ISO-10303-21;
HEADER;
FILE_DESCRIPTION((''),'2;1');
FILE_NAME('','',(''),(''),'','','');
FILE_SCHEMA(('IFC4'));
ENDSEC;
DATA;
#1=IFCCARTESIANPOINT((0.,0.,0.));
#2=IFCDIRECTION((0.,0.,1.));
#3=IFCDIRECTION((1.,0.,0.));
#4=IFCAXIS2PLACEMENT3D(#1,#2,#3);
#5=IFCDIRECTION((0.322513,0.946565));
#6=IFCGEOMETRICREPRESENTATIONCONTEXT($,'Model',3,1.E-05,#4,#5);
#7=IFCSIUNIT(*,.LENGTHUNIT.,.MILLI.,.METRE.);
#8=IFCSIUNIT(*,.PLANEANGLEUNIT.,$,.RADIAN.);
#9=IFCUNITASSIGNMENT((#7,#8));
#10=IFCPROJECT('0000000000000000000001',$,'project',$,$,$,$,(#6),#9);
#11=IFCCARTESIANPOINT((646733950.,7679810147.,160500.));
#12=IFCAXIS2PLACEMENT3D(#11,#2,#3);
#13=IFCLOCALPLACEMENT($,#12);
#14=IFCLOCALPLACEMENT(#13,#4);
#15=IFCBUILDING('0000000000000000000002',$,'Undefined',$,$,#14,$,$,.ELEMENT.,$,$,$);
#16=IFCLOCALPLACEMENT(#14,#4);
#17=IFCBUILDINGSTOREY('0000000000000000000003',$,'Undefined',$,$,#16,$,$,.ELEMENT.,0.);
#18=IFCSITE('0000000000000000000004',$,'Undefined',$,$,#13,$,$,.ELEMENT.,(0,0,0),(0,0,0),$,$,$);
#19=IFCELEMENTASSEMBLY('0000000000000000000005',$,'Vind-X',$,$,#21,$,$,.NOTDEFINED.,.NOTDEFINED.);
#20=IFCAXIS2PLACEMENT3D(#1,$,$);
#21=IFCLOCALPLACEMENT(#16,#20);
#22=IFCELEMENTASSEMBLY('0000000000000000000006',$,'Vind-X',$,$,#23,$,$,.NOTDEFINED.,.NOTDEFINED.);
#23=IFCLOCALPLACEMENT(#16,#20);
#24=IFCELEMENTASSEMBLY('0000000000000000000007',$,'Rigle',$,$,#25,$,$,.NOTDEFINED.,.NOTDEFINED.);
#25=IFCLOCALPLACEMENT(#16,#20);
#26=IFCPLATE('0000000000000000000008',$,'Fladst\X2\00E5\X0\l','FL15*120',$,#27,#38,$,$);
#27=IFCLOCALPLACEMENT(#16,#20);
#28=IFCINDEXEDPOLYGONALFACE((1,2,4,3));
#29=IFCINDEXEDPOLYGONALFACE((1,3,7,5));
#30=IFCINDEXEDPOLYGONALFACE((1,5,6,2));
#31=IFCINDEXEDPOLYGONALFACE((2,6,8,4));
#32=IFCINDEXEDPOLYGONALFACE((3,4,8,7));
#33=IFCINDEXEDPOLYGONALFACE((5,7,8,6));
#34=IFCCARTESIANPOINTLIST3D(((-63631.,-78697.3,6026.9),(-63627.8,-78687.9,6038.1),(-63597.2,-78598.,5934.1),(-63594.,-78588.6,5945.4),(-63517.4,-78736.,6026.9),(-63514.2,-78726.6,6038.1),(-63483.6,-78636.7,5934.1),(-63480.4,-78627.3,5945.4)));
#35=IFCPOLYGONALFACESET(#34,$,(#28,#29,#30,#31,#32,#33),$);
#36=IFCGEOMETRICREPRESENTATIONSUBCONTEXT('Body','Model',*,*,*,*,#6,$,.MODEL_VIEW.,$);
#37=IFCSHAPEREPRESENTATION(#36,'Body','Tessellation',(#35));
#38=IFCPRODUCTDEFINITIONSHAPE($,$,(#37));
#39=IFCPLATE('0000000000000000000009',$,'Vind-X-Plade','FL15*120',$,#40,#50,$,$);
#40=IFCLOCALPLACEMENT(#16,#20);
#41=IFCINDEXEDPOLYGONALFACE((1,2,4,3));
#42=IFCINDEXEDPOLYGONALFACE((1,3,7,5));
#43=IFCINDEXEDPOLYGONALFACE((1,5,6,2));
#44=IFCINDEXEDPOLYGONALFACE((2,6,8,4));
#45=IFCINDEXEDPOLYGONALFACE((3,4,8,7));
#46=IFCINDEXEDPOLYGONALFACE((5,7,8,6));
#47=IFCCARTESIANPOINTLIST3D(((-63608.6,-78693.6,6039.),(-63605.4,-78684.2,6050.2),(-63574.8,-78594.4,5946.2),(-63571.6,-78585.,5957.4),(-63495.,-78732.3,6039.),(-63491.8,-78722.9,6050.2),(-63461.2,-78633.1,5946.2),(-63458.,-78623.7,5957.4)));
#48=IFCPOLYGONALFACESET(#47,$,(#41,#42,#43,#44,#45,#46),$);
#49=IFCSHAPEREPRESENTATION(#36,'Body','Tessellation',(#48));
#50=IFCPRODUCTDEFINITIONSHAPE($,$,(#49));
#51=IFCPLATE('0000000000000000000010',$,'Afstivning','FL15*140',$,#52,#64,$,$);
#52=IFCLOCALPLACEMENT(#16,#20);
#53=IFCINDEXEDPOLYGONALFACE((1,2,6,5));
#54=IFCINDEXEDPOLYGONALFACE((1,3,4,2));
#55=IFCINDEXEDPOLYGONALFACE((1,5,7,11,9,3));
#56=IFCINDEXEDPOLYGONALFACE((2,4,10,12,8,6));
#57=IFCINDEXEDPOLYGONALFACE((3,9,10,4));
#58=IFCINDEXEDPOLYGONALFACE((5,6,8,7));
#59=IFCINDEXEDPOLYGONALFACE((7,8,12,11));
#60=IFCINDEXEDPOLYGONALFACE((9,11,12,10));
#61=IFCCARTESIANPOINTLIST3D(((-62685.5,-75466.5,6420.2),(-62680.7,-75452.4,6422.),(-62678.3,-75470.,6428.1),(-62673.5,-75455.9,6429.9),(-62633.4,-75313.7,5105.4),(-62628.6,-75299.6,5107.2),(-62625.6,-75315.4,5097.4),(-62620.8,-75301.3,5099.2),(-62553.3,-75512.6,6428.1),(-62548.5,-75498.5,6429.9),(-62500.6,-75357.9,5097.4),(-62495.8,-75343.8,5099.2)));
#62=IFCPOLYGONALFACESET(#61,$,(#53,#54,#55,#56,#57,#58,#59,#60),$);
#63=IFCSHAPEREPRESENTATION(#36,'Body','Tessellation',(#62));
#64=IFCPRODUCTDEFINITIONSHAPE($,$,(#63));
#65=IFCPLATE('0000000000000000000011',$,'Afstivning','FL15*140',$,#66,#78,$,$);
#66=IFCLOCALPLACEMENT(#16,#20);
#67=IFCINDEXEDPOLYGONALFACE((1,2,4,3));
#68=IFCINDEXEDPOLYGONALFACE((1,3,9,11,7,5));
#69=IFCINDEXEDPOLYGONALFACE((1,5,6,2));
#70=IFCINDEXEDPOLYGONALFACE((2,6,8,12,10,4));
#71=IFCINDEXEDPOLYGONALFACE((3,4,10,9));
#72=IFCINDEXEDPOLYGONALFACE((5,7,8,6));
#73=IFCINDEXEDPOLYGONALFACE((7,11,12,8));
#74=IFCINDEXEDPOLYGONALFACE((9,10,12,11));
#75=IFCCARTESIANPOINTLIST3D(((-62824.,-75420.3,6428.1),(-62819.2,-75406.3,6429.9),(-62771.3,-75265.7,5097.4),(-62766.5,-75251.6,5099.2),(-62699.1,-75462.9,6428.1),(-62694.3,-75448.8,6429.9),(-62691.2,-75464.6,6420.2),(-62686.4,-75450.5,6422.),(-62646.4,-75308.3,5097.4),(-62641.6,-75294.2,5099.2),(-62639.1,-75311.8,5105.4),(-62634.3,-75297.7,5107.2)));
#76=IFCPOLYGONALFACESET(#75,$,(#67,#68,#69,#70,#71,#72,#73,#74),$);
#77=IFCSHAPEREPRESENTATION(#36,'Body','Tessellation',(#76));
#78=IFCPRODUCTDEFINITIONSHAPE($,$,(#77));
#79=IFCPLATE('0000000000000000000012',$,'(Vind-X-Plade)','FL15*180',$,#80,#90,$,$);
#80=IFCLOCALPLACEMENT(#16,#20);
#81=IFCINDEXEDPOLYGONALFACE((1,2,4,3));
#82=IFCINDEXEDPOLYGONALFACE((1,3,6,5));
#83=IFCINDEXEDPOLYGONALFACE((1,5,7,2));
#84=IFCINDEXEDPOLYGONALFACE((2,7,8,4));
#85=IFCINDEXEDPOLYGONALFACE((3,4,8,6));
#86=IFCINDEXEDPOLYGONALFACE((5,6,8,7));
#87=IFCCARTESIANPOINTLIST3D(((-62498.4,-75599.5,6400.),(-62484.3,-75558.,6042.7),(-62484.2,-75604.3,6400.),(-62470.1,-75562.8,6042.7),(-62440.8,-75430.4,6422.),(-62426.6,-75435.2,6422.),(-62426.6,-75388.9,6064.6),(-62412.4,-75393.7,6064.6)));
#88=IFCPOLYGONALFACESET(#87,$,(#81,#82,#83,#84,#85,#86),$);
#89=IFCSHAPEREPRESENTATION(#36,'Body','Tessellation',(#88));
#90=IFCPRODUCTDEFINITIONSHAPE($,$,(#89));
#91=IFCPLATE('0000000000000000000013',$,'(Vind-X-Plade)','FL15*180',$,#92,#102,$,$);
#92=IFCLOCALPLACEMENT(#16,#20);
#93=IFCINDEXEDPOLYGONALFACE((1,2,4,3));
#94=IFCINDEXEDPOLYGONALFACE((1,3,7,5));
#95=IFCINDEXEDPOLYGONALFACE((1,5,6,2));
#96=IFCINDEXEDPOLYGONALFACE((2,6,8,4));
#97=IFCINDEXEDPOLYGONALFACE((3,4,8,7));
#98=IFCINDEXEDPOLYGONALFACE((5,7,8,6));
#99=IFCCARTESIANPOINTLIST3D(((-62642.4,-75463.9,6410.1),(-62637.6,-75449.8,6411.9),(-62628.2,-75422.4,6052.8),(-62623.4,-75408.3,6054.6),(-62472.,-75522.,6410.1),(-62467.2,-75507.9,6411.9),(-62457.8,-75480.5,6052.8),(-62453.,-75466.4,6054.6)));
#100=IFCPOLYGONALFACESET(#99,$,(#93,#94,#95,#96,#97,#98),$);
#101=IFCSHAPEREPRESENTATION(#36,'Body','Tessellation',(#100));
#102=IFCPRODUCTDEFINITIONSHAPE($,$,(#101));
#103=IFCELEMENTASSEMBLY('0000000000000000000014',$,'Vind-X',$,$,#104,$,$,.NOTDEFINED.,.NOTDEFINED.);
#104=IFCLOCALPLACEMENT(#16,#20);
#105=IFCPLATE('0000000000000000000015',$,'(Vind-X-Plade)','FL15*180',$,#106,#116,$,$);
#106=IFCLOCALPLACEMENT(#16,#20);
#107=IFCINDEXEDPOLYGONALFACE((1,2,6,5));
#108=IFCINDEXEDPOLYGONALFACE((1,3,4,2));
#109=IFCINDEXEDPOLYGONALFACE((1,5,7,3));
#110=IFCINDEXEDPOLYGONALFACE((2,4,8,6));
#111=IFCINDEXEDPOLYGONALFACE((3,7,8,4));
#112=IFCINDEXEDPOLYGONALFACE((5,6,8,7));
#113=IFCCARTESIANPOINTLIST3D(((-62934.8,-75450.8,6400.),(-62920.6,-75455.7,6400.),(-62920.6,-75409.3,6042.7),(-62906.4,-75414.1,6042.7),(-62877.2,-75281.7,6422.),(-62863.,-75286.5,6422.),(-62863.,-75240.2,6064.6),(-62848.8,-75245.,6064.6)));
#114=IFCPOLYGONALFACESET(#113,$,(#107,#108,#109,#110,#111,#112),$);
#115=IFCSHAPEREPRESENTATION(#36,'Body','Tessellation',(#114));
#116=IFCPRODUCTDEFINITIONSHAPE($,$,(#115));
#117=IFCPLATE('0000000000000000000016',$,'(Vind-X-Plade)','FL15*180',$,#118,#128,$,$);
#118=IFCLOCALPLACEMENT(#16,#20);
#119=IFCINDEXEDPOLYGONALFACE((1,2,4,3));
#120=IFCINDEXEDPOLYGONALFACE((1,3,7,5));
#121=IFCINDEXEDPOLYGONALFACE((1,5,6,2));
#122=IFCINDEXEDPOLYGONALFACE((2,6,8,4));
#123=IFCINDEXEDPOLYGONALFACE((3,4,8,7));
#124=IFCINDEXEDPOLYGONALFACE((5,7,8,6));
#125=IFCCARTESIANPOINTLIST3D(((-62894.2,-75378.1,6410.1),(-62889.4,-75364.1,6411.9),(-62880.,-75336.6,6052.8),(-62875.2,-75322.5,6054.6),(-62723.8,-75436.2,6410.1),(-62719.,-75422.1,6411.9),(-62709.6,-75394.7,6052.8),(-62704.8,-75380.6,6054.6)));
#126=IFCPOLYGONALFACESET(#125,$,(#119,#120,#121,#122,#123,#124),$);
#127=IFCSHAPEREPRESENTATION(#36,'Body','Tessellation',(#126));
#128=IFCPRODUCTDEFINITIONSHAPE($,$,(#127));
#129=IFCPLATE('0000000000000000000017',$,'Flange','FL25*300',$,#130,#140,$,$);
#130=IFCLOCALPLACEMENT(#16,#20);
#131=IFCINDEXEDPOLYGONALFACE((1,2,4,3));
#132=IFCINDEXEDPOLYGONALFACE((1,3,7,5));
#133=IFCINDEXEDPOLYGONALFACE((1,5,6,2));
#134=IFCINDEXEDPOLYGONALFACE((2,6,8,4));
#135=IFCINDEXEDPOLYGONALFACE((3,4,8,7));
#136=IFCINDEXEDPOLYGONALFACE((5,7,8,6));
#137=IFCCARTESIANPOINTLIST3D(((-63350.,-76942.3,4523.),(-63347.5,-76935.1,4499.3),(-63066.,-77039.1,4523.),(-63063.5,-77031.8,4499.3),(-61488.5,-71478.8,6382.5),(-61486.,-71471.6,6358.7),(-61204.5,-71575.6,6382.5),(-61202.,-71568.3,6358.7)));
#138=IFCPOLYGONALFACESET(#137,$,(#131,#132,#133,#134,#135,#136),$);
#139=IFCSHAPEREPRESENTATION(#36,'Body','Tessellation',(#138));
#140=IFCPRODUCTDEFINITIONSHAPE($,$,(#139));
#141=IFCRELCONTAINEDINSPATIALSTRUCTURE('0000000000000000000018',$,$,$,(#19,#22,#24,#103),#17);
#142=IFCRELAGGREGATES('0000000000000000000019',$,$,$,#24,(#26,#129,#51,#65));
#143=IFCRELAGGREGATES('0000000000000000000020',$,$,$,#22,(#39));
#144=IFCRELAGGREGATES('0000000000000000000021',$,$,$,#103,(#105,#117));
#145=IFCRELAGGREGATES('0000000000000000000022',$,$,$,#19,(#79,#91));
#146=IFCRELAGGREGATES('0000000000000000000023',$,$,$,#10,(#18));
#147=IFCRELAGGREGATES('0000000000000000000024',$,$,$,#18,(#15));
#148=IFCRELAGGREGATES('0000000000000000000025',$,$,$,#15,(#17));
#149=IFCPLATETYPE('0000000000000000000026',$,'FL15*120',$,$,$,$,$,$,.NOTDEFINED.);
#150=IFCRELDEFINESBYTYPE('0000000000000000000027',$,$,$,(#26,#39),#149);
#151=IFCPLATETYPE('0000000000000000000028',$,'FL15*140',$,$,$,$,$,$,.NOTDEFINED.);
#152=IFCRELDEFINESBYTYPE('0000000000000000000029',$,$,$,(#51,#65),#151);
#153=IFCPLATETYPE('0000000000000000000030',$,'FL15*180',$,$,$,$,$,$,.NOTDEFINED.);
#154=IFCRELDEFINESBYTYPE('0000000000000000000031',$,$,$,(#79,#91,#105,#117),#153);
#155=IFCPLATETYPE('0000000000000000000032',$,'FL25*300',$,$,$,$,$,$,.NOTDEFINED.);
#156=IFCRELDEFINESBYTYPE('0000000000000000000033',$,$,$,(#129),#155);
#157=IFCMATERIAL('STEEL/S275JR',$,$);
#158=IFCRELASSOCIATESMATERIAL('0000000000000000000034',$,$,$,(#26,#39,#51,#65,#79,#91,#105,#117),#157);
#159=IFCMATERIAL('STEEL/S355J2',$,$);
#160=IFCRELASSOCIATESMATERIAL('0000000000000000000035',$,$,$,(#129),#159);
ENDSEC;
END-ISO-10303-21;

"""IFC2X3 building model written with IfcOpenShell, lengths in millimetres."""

from ifc_helpers import new_model, si_unit, direction, frame, origin_with_axes, place, context, subcontext, project, spatial, polyline, outline, extrude, clip, halfspace, material, type_object, element, aggregate, save


model = new_model("IFC2X3")

# Units and contexts
model_context = context("Model", 3, precision=1e-05, world=origin_with_axes(), true_north=direction((0.322513, 0.946565)))
body_context = subcontext(model_context, "Body", "Model", "MODEL_VIEW")
ifc_project = project(units=[si_unit("LENGTHUNIT", "METRE", prefix="MILLI"), si_unit("PLANEANGLEUNIT", "RADIAN")], contexts=[model_context])

# Site, building, storey
site_placement = place(None, frame((646733950.0, 7679810147.0, 160500.0), z_axis=(0.0, 0.0, 1.0), x_axis=(1.0, 0.0, 0.0)))
site = spatial("IfcSite", under=ifc_project, at=site_placement, Name="Undefined", CompositionType="ELEMENT", RefLatitude=(0, 0, 0), RefLongitude=(0, 0, 0))
building_placement = place(site_placement, origin_with_axes())
building = spatial("IfcBuilding", under=site, at=building_placement, Name="Undefined", CompositionType="ELEMENT")
storey_placement = place(building_placement, origin_with_axes())
storey = spatial("IfcBuildingStorey", under=building, at=storey_placement, Name="Undefined", CompositionType="ELEMENT", Elevation=0.0)

# Shared definitions
ifc_material_1 = material(Name="STEEL/S275JR")

# Element assembly
assembly_1_placement = place(storey_placement, origin_with_axes())
assembly_1 = element("IfcElementAssembly", 1, at=assembly_1_placement, inside=storey, Name="Vind-X", AssemblyPlace="NOTDEFINED", PredefinedType="NOTDEFINED")

# Shared definitions
ifc_material_2 = material(Name="STEEL/S355J2")

# Element assembly
assembly_2_placement = place(storey_placement, origin_with_axes())
assembly_2 = element("IfcElementAssembly", 2, at=assembly_2_placement, inside=storey, Name="Vind-X", AssemblyPlace="NOTDEFINED", PredefinedType="NOTDEFINED")

# Element assembly, plate
plate_type_1 = type_object("IfcPlateType", Name="FL15*120", PredefinedType="NOTDEFINED")
assembly_3_placement = place(storey_placement, origin_with_axes())
assembly_3 = element("IfcElementAssembly", 3, at=assembly_3_placement, inside=storey, Name="Rigle", AssemblyPlace="NOTDEFINED", PredefinedType="NOTDEFINED")
plate_1_placement = place(assembly_3_placement, frame((-63595.6, -78593.3, 5939.7), z_axis=(0.213703, 0.627213, 0.748956), x_axis=(-0.241548, -0.708935, 0.66262)))
plate_1 = element("IfcPlate", 4, at=plate_1_placement, type_object=plate_type_1, material=ifc_material_1, Name="Fladstål", Description="FL15*120", context=body_context, shape_type="SweptSolid", body=[
    extrude(outline(polyline([(0.0, 0.0), (140.0, 0.0), (140.0, 120.0), (0.0, 120.0), (0.0, 0.0)])), frame((0.0, 0.0, -7.5), z_axis=(0.0, 0.0, 1.0), x_axis=(1.0, 0.0, 0.0)), (0.0, 0.0, 1.0), 15.0),
])

# Plates
plate_2_placement = place(assembly_2_placement, frame((-63590.1, -78639.3, 5998.2), z_axis=(-0.213703, -0.627213, -0.748956), x_axis=(0.946565, -0.322513, 0.0)))
plate_2 = element("IfcPlate", 5, at=plate_2_placement, type_object=plate_type_1, material=ifc_material_1, Name="Vind-X-Plade", Description="FL15*120", context=body_context, shape_type="SweptSolid", body=[
    extrude(outline(polyline([(0.0, -70.0), (0.0, 70.0), (120.0, 70.0), (120.0, -70.0), (0.0, -70.0)])), frame((0.0, 0.0, -7.5), z_axis=(0.0, 0.0, 1.0), x_axis=(1.0, 0.0, 0.0)), (0.0, 0.0, 1.0), 15.0),
])
plate_type_2 = type_object("IfcPlateType", Name="FL15*140", PredefinedType="NOTDEFINED")
plate_3_placement = place(assembly_3_placement, frame((-62498.2, -75350.9, 5098.3), z_axis=(0.320109, 0.93951, 0.121869), x_axis=(-0.946565, 0.322513, 0.0)))
plate_3 = element("IfcPlate", 6, at=plate_3_placement, type_object=plate_type_2, material=ifc_material_1, Name="Afstivning", Description="FL15*140", context=body_context, shape_type="SweptSolid", body=[
    extrude(outline(polyline([(0.0, 0.0), (132.0, 0.0), (140.0, 8.0), (140.0, 1332.7), (132.0, 1340.7), (0.0, 1340.7), (0.0, 0.0)])), frame((0.0, 0.0, -7.5), z_axis=(0.0, 0.0, 1.0), x_axis=(1.0, 0.0, 0.0)), (0.0, 0.0, 1.0), 15.0),
])
plate_4_placement = place(assembly_3_placement, frame((-62636.4, -75303.8, 5098.3), z_axis=(0.320109, 0.93951, 0.121869), x_axis=(-0.946565, 0.322513, 0.0)))
plate_4 = element("IfcPlate", 7, at=plate_4_placement, type_object=plate_type_2, material=ifc_material_1, Name="Afstivning", Description="FL15*140", context=body_context, shape_type="SweptSolid", body=[
    extrude(outline(polyline([(0.0, 8.0), (8.0, 0.0), (140.0, 0.0), (140.0, 1340.7), (8.0, 1340.7), (0.0, 1332.7), (0.0, 8.0)])), frame((0.0, 0.0, -7.5), z_axis=(0.0, 0.0, 1.0), x_axis=(1.0, 0.0, 0.0)), (0.0, 0.0, 1.0), 15.0),
])
plate_type_3 = type_object("IfcPlateType", Name="FL15*180", PredefinedType="NOTDEFINED")
plate_5_placement = place(assembly_1_placement, frame((-62491.3, -75601.9, 6400.0), z_axis=(-0.946565, 0.322513, 0.0), x_axis=(0.320109, 0.93951, 0.121869)))
plate_5 = element("IfcPlate", 8, at=plate_5_placement, type_object=plate_type_3, material=ifc_material_1, Name="(Vind-X-Plade)", Description="FL15*180", context=body_context, shape_type="SweptSolid", body=[
    extrude(outline(polyline([(0.0, 0.0), (180.0, 0.0), (180.0, 360.0), (0.0, 360.0), (0.0, 0.0)])), frame((0.0, 0.0, -7.5), z_axis=(0.0, 0.0, 1.0), x_axis=(1.0, 0.0, 0.0)), (0.0, 0.0, 1.0), 15.0),
])
plate_6_placement = place(assembly_1_placement, frame((-62625.8, -75415.4, 6053.7), z_axis=(0.320109, 0.93951, 0.121869), x_axis=(-0.039304, -0.115357, 0.992546)))
plate_6 = element("IfcPlate", 9, at=plate_6_placement, type_object=plate_type_3, material=ifc_material_1, Name="(Vind-X-Plade)", Description="FL15*180", context=body_context, shape_type="SweptSolid", body=[
    extrude(outline(polyline([(0.0, 0.0), (360.0, 0.0), (360.0, 180.0), (0.0, 180.0), (0.0, 0.0)])), frame((0.0, 0.0, -7.5), z_axis=(0.0, 0.0, 1.0), x_axis=(1.0, 0.0, 0.0)), (0.0, 0.0, 1.0), 15.0),
])

# Element assembly, plates
assembly_4_placement = place(storey_placement, origin_with_axes())
assembly_4 = element("IfcElementAssembly", 10, at=assembly_4_placement, inside=storey, Name="Vind-X", AssemblyPlace="NOTDEFINED", PredefinedType="NOTDEFINED")
plate_7_placement = place(assembly_4_placement, frame((-62870.1, -75284.1, 6422.0), z_axis=(0.946565, -0.322513, 0.0), x_axis=(-0.320109, -0.93951, -0.121869)))
plate_7 = element("IfcPlate", 11, at=plate_7_placement, type_object=plate_type_3, material=ifc_material_1, Name="(Vind-X-Plade)", Description="FL15*180", context=body_context, shape_type="SweptSolid", body=[
    extrude(outline(polyline([(0.0, 0.0), (180.0, 0.0), (180.0, 360.0), (0.0, 360.0), (0.0, 0.0)])), frame((0.0, 0.0, -7.5), z_axis=(0.0, 0.0, 1.0), x_axis=(1.0, 0.0, 0.0)), (0.0, 0.0, 1.0), 15.0),
])
plate_8_placement = place(assembly_4_placement, frame((-62707.2, -75387.6, 6053.7), z_axis=(-0.320109, -0.93951, -0.121869), x_axis=(-0.039304, -0.115357, 0.992546)))
plate_8 = element("IfcPlate", 12, at=plate_8_placement, type_object=plate_type_3, material=ifc_material_1, Name="(Vind-X-Plade)", Description="FL15*180", context=body_context, shape_type="SweptSolid", body=[
    extrude(outline(polyline([(0.0, 0.0), (360.0, 0.0), (360.0, 180.0), (0.0, 180.0), (0.0, 0.0)])), frame((0.0, 0.0, -7.5), z_axis=(0.0, 0.0, 1.0), x_axis=(1.0, 0.0, 0.0)), (0.0, 0.0, 1.0), 15.0),
])

# Plate
plate_type_4 = type_object("IfcPlateType", Name="FL25*300", PredefinedType="NOTDEFINED")
plate_9_placement = place(assembly_3_placement, frame((-63206.8, -76987.1, 4511.2), z_axis=(0.098895, 0.290253, -0.951826), x_axis=(0.306976, 0.900965, 0.306638)))
plate_9 = element("IfcPlate", 13, at=plate_9_placement, type_object=plate_type_4, material=ifc_material_2, Name="Flange", Description="FL25*300", context=body_context, shape_type="Clipping", body=[
    clip(extrude(outline(polyline([(0.0, -150.0), (0.0, 150.0), (6064.1, 150.0), (6064.1, -150.0), (0.0, -150.0)])), frame((0.0, 0.0, -12.5), z_axis=(0.0, 0.0, 1.0), x_axis=(1.0, 0.0, 0.0)), (0.0, 0.0, 1.0), 25.0), halfspace(frame((6064.1, 0.0, 0.3), z_axis=(1.0, 0.0, 0.0), x_axis=(0.0, 1.0, 0.0)), False)),
])
aggregate(assembly_3, [plate_1, plate_9, plate_3, plate_4])

aggregate(assembly_2, [plate_2])
aggregate(assembly_4, [plate_7, plate_8])
aggregate(assembly_1, [plate_5, plate_6])

save(model, "model.ifc")
